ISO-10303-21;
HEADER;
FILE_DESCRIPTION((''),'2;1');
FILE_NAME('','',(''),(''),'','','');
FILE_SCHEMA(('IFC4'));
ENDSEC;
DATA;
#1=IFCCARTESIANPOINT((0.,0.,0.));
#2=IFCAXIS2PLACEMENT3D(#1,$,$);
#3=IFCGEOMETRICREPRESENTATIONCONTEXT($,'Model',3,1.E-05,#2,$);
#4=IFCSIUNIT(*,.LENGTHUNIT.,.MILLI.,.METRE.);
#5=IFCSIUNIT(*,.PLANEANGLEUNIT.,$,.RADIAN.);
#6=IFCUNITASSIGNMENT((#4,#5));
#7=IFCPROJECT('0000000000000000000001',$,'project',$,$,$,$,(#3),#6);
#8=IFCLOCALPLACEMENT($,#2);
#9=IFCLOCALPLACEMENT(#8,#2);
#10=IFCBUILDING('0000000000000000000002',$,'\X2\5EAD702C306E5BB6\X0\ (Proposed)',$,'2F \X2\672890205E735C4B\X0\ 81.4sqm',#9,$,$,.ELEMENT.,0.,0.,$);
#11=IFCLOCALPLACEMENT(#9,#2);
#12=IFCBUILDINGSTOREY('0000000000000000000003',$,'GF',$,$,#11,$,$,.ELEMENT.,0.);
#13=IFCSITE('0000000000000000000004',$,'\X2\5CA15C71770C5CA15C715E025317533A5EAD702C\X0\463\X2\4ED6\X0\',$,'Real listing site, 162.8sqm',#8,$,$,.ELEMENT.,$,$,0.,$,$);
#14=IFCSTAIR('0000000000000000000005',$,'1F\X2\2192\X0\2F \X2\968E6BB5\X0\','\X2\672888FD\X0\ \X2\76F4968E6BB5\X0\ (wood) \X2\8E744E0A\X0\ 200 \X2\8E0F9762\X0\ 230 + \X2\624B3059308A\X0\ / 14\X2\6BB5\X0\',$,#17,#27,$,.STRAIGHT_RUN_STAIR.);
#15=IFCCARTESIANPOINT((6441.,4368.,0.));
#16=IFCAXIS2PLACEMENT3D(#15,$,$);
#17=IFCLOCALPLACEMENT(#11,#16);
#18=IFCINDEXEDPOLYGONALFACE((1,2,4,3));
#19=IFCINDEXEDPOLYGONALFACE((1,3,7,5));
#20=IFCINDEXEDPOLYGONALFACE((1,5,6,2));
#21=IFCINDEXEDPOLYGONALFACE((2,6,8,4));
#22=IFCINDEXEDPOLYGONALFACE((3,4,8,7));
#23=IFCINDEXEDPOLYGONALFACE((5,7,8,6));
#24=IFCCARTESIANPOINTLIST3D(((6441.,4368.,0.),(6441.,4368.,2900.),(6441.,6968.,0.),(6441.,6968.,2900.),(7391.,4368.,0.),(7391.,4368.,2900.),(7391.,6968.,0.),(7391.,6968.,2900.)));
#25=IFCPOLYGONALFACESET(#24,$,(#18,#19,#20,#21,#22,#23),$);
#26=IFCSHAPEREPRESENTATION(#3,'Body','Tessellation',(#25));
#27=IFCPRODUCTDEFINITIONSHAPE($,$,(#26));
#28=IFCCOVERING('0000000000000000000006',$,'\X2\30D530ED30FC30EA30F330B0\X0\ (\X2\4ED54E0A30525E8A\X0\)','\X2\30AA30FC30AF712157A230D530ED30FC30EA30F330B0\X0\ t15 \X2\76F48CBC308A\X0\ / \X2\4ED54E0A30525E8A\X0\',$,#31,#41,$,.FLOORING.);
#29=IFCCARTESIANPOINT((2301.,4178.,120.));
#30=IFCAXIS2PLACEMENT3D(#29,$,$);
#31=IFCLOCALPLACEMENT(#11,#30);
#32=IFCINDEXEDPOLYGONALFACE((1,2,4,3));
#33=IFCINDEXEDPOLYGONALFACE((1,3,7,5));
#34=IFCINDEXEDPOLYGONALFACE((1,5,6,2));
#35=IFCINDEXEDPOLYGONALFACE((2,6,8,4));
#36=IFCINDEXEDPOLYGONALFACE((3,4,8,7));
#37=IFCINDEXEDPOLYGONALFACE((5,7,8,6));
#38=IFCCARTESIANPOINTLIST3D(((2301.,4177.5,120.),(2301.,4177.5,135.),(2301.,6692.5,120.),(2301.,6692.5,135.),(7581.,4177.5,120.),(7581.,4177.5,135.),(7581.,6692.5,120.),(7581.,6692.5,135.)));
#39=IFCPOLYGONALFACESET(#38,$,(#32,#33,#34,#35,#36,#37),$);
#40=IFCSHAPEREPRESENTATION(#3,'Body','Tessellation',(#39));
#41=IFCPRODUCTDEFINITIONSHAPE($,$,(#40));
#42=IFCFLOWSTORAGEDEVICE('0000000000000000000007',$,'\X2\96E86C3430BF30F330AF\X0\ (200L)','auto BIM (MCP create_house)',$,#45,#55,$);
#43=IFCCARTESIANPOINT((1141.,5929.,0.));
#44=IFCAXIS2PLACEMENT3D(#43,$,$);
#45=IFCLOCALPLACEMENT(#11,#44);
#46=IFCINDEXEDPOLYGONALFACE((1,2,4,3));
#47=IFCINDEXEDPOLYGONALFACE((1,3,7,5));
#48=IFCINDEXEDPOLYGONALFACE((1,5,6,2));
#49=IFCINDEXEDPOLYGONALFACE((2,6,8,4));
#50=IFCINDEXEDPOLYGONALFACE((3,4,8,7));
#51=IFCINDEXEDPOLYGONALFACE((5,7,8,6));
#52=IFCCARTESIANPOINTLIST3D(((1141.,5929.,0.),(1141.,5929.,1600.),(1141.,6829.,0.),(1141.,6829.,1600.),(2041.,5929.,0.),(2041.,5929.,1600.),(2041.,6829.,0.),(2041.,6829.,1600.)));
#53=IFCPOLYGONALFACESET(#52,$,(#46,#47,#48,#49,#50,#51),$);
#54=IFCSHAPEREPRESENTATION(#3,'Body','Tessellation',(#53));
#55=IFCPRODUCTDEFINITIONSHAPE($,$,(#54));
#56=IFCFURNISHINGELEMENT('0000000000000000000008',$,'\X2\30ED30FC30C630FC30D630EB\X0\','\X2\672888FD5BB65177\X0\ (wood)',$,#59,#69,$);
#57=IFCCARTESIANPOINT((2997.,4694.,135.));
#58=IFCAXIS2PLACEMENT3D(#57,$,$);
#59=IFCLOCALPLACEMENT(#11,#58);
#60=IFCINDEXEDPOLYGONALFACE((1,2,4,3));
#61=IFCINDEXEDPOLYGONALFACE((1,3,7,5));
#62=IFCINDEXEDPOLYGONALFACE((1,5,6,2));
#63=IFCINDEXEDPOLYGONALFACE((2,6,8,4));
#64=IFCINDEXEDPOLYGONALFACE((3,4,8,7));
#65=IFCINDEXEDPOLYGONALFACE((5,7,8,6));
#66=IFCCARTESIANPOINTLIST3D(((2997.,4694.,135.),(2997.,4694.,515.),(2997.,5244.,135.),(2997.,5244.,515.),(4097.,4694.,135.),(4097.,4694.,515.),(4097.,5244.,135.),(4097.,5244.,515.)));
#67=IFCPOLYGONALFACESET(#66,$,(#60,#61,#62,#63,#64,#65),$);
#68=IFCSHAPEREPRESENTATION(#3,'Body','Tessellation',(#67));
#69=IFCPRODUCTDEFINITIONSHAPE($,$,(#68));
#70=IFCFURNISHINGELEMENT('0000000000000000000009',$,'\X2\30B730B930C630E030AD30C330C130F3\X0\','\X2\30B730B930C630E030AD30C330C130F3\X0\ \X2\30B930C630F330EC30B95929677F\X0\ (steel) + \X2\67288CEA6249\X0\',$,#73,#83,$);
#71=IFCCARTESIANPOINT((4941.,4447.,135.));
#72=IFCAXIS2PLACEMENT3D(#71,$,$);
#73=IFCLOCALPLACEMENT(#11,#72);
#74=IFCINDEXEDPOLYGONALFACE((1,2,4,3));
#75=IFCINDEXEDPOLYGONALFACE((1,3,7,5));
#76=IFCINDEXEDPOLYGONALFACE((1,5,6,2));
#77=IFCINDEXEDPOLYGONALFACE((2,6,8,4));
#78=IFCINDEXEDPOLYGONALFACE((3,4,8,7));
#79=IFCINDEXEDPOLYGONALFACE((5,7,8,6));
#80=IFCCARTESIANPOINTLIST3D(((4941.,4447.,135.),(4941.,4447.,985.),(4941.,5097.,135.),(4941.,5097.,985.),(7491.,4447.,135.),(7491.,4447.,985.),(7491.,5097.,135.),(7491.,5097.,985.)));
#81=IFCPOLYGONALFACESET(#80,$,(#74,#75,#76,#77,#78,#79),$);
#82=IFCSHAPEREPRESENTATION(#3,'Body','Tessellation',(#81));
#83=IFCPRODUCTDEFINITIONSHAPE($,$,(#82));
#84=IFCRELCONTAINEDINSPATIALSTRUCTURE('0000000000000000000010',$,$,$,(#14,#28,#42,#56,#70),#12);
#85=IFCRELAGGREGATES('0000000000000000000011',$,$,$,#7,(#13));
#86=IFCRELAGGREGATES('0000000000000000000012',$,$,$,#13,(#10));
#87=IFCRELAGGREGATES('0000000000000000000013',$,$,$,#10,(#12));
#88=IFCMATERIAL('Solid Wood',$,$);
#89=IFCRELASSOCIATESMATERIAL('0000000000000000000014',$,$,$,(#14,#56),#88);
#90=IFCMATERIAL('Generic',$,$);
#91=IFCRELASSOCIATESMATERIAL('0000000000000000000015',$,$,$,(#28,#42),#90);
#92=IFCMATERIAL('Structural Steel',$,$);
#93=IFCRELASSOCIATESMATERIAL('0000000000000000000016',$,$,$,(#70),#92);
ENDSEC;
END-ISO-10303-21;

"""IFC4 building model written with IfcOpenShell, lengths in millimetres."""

from ifc_helpers import new_model, si_unit, frame, frame_2d, origin, place, context, project, spatial, rectangle, extrude, material, element, save


model = new_model("IFC4")

# Units and contexts
model_context = context("Model", 3, precision=1e-05, world=origin())
ifc_project = project(units=[si_unit("LENGTHUNIT", "METRE", prefix="MILLI"), si_unit("PLANEANGLEUNIT", "RADIAN")], contexts=[model_context])

# Site, building, storey
site_placement = place(None, origin())
site = spatial("IfcSite", under=ifc_project, at=site_placement, Name="岡山県岡山市北区庭瀬463他", ObjectType="Real listing site, 162.8sqm", CompositionType="ELEMENT", RefElevation=0.0)
building_placement = place(site_placement, origin())
building = spatial("IfcBuilding", under=site, at=building_placement, Name="庭瀬の家 (Proposed)", ObjectType="2F 木造平屋 81.4sqm", CompositionType="ELEMENT", ElevationOfRefHeight=0.0, ElevationOfTerrain=0.0)
storey_placement = place(building_placement, origin())
storey = spatial("IfcBuildingStorey", under=building, at=storey_placement, Name="GF", CompositionType="ELEMENT", Elevation=0.0)

# Shared definitions
ifc_material_1 = material(Name="Solid Wood")

# Stair
stair_placement = place(storey_placement, frame((6441.0, 4368.0, 0.0)))
element("IfcStair", 1, at=stair_placement, inside=storey, material=ifc_material_1, Name="1F→2F 階段", Description="木製 直階段 (wood) 蹴上 200 踏面 230 + 手すり / 14段", PredefinedType="STRAIGHT_RUN_STAIR", context=model_context, shape_type="SweptSolid", body=[
    extrude(rectangle(XDim=950.0, YDim=2600.0, at=frame_2d((475.0, 1300.0))), frame((6441.0, 4368.0, 0.0)), (0.0, 0.0, 1.0), 2900.0),
])

# Covering
ifc_material_2 = material(Name="Generic")
covering_placement = place(storey_placement, frame((2301.0, 4178.0, 120.0)))
element("IfcCovering", 2, at=covering_placement, inside=storey, material=ifc_material_2, Name="フローリング (仕上げ床)", Description="オーク無垢フローリング t15 直貼り / 仕上げ床", PredefinedType="FLOORING", context=model_context, shape_type="SweptSolid", body=[
    extrude(rectangle(XDim=5280.0, YDim=2515.0, at=frame_2d((2640.0, 1257.0))), frame((2301.0, 4178.0, 120.0)), (0.0, 0.0, 1.0), 15.0),
])

# Flow storage device
flow_storage_device_placement = place(storey_placement, frame((1141.0, 5929.0, 0.0)))
element("IfcFlowStorageDevice", 3, at=flow_storage_device_placement, inside=storey, material=ifc_material_2, Name="雨水タンク (200L)", Description="auto BIM (MCP create_house)", context=model_context, shape_type="SweptSolid", body=[
    extrude(rectangle(XDim=900.0, YDim=900.0, at=frame_2d((450.0, 450.0))), frame((1141.0, 5929.0, 0.0)), (0.0, 0.0, 1.0), 1600.0),
])

# Furnishing elements
furnishing_1_placement = place(storey_placement, frame((2997.0, 4694.0, 135.0)))
element("IfcFurnishingElement", 4, at=furnishing_1_placement, inside=storey, material=ifc_material_1, Name="ローテーブル", Description="木製家具 (wood)", context=model_context, shape_type="SweptSolid", body=[
    extrude(rectangle(XDim=1100.0, YDim=550.0, at=frame_2d((550.0, 275.0))), frame((2997.0, 4694.0, 135.0)), (0.0, 0.0, 1.0), 380.0),
])
ifc_material_3 = material(Name="Structural Steel")
furnishing_2_placement = place(storey_placement, frame((4941.0, 4447.0, 135.0)))
element("IfcFurnishingElement", 5, at=furnishing_2_placement, inside=storey, material=ifc_material_3, Name="システムキッチン", Description="システムキッチン ステンレス天板 (steel) + 木質扉", context=model_context, shape_type="SweptSolid", body=[
    extrude(rectangle(XDim=2550.0, YDim=650.0, at=frame_2d((1275.0, 325.0))), frame((4941.0, 4447.0, 135.0)), (0.0, 0.0, 1.0), 850.0),
])

save(model, "model.ifc")
